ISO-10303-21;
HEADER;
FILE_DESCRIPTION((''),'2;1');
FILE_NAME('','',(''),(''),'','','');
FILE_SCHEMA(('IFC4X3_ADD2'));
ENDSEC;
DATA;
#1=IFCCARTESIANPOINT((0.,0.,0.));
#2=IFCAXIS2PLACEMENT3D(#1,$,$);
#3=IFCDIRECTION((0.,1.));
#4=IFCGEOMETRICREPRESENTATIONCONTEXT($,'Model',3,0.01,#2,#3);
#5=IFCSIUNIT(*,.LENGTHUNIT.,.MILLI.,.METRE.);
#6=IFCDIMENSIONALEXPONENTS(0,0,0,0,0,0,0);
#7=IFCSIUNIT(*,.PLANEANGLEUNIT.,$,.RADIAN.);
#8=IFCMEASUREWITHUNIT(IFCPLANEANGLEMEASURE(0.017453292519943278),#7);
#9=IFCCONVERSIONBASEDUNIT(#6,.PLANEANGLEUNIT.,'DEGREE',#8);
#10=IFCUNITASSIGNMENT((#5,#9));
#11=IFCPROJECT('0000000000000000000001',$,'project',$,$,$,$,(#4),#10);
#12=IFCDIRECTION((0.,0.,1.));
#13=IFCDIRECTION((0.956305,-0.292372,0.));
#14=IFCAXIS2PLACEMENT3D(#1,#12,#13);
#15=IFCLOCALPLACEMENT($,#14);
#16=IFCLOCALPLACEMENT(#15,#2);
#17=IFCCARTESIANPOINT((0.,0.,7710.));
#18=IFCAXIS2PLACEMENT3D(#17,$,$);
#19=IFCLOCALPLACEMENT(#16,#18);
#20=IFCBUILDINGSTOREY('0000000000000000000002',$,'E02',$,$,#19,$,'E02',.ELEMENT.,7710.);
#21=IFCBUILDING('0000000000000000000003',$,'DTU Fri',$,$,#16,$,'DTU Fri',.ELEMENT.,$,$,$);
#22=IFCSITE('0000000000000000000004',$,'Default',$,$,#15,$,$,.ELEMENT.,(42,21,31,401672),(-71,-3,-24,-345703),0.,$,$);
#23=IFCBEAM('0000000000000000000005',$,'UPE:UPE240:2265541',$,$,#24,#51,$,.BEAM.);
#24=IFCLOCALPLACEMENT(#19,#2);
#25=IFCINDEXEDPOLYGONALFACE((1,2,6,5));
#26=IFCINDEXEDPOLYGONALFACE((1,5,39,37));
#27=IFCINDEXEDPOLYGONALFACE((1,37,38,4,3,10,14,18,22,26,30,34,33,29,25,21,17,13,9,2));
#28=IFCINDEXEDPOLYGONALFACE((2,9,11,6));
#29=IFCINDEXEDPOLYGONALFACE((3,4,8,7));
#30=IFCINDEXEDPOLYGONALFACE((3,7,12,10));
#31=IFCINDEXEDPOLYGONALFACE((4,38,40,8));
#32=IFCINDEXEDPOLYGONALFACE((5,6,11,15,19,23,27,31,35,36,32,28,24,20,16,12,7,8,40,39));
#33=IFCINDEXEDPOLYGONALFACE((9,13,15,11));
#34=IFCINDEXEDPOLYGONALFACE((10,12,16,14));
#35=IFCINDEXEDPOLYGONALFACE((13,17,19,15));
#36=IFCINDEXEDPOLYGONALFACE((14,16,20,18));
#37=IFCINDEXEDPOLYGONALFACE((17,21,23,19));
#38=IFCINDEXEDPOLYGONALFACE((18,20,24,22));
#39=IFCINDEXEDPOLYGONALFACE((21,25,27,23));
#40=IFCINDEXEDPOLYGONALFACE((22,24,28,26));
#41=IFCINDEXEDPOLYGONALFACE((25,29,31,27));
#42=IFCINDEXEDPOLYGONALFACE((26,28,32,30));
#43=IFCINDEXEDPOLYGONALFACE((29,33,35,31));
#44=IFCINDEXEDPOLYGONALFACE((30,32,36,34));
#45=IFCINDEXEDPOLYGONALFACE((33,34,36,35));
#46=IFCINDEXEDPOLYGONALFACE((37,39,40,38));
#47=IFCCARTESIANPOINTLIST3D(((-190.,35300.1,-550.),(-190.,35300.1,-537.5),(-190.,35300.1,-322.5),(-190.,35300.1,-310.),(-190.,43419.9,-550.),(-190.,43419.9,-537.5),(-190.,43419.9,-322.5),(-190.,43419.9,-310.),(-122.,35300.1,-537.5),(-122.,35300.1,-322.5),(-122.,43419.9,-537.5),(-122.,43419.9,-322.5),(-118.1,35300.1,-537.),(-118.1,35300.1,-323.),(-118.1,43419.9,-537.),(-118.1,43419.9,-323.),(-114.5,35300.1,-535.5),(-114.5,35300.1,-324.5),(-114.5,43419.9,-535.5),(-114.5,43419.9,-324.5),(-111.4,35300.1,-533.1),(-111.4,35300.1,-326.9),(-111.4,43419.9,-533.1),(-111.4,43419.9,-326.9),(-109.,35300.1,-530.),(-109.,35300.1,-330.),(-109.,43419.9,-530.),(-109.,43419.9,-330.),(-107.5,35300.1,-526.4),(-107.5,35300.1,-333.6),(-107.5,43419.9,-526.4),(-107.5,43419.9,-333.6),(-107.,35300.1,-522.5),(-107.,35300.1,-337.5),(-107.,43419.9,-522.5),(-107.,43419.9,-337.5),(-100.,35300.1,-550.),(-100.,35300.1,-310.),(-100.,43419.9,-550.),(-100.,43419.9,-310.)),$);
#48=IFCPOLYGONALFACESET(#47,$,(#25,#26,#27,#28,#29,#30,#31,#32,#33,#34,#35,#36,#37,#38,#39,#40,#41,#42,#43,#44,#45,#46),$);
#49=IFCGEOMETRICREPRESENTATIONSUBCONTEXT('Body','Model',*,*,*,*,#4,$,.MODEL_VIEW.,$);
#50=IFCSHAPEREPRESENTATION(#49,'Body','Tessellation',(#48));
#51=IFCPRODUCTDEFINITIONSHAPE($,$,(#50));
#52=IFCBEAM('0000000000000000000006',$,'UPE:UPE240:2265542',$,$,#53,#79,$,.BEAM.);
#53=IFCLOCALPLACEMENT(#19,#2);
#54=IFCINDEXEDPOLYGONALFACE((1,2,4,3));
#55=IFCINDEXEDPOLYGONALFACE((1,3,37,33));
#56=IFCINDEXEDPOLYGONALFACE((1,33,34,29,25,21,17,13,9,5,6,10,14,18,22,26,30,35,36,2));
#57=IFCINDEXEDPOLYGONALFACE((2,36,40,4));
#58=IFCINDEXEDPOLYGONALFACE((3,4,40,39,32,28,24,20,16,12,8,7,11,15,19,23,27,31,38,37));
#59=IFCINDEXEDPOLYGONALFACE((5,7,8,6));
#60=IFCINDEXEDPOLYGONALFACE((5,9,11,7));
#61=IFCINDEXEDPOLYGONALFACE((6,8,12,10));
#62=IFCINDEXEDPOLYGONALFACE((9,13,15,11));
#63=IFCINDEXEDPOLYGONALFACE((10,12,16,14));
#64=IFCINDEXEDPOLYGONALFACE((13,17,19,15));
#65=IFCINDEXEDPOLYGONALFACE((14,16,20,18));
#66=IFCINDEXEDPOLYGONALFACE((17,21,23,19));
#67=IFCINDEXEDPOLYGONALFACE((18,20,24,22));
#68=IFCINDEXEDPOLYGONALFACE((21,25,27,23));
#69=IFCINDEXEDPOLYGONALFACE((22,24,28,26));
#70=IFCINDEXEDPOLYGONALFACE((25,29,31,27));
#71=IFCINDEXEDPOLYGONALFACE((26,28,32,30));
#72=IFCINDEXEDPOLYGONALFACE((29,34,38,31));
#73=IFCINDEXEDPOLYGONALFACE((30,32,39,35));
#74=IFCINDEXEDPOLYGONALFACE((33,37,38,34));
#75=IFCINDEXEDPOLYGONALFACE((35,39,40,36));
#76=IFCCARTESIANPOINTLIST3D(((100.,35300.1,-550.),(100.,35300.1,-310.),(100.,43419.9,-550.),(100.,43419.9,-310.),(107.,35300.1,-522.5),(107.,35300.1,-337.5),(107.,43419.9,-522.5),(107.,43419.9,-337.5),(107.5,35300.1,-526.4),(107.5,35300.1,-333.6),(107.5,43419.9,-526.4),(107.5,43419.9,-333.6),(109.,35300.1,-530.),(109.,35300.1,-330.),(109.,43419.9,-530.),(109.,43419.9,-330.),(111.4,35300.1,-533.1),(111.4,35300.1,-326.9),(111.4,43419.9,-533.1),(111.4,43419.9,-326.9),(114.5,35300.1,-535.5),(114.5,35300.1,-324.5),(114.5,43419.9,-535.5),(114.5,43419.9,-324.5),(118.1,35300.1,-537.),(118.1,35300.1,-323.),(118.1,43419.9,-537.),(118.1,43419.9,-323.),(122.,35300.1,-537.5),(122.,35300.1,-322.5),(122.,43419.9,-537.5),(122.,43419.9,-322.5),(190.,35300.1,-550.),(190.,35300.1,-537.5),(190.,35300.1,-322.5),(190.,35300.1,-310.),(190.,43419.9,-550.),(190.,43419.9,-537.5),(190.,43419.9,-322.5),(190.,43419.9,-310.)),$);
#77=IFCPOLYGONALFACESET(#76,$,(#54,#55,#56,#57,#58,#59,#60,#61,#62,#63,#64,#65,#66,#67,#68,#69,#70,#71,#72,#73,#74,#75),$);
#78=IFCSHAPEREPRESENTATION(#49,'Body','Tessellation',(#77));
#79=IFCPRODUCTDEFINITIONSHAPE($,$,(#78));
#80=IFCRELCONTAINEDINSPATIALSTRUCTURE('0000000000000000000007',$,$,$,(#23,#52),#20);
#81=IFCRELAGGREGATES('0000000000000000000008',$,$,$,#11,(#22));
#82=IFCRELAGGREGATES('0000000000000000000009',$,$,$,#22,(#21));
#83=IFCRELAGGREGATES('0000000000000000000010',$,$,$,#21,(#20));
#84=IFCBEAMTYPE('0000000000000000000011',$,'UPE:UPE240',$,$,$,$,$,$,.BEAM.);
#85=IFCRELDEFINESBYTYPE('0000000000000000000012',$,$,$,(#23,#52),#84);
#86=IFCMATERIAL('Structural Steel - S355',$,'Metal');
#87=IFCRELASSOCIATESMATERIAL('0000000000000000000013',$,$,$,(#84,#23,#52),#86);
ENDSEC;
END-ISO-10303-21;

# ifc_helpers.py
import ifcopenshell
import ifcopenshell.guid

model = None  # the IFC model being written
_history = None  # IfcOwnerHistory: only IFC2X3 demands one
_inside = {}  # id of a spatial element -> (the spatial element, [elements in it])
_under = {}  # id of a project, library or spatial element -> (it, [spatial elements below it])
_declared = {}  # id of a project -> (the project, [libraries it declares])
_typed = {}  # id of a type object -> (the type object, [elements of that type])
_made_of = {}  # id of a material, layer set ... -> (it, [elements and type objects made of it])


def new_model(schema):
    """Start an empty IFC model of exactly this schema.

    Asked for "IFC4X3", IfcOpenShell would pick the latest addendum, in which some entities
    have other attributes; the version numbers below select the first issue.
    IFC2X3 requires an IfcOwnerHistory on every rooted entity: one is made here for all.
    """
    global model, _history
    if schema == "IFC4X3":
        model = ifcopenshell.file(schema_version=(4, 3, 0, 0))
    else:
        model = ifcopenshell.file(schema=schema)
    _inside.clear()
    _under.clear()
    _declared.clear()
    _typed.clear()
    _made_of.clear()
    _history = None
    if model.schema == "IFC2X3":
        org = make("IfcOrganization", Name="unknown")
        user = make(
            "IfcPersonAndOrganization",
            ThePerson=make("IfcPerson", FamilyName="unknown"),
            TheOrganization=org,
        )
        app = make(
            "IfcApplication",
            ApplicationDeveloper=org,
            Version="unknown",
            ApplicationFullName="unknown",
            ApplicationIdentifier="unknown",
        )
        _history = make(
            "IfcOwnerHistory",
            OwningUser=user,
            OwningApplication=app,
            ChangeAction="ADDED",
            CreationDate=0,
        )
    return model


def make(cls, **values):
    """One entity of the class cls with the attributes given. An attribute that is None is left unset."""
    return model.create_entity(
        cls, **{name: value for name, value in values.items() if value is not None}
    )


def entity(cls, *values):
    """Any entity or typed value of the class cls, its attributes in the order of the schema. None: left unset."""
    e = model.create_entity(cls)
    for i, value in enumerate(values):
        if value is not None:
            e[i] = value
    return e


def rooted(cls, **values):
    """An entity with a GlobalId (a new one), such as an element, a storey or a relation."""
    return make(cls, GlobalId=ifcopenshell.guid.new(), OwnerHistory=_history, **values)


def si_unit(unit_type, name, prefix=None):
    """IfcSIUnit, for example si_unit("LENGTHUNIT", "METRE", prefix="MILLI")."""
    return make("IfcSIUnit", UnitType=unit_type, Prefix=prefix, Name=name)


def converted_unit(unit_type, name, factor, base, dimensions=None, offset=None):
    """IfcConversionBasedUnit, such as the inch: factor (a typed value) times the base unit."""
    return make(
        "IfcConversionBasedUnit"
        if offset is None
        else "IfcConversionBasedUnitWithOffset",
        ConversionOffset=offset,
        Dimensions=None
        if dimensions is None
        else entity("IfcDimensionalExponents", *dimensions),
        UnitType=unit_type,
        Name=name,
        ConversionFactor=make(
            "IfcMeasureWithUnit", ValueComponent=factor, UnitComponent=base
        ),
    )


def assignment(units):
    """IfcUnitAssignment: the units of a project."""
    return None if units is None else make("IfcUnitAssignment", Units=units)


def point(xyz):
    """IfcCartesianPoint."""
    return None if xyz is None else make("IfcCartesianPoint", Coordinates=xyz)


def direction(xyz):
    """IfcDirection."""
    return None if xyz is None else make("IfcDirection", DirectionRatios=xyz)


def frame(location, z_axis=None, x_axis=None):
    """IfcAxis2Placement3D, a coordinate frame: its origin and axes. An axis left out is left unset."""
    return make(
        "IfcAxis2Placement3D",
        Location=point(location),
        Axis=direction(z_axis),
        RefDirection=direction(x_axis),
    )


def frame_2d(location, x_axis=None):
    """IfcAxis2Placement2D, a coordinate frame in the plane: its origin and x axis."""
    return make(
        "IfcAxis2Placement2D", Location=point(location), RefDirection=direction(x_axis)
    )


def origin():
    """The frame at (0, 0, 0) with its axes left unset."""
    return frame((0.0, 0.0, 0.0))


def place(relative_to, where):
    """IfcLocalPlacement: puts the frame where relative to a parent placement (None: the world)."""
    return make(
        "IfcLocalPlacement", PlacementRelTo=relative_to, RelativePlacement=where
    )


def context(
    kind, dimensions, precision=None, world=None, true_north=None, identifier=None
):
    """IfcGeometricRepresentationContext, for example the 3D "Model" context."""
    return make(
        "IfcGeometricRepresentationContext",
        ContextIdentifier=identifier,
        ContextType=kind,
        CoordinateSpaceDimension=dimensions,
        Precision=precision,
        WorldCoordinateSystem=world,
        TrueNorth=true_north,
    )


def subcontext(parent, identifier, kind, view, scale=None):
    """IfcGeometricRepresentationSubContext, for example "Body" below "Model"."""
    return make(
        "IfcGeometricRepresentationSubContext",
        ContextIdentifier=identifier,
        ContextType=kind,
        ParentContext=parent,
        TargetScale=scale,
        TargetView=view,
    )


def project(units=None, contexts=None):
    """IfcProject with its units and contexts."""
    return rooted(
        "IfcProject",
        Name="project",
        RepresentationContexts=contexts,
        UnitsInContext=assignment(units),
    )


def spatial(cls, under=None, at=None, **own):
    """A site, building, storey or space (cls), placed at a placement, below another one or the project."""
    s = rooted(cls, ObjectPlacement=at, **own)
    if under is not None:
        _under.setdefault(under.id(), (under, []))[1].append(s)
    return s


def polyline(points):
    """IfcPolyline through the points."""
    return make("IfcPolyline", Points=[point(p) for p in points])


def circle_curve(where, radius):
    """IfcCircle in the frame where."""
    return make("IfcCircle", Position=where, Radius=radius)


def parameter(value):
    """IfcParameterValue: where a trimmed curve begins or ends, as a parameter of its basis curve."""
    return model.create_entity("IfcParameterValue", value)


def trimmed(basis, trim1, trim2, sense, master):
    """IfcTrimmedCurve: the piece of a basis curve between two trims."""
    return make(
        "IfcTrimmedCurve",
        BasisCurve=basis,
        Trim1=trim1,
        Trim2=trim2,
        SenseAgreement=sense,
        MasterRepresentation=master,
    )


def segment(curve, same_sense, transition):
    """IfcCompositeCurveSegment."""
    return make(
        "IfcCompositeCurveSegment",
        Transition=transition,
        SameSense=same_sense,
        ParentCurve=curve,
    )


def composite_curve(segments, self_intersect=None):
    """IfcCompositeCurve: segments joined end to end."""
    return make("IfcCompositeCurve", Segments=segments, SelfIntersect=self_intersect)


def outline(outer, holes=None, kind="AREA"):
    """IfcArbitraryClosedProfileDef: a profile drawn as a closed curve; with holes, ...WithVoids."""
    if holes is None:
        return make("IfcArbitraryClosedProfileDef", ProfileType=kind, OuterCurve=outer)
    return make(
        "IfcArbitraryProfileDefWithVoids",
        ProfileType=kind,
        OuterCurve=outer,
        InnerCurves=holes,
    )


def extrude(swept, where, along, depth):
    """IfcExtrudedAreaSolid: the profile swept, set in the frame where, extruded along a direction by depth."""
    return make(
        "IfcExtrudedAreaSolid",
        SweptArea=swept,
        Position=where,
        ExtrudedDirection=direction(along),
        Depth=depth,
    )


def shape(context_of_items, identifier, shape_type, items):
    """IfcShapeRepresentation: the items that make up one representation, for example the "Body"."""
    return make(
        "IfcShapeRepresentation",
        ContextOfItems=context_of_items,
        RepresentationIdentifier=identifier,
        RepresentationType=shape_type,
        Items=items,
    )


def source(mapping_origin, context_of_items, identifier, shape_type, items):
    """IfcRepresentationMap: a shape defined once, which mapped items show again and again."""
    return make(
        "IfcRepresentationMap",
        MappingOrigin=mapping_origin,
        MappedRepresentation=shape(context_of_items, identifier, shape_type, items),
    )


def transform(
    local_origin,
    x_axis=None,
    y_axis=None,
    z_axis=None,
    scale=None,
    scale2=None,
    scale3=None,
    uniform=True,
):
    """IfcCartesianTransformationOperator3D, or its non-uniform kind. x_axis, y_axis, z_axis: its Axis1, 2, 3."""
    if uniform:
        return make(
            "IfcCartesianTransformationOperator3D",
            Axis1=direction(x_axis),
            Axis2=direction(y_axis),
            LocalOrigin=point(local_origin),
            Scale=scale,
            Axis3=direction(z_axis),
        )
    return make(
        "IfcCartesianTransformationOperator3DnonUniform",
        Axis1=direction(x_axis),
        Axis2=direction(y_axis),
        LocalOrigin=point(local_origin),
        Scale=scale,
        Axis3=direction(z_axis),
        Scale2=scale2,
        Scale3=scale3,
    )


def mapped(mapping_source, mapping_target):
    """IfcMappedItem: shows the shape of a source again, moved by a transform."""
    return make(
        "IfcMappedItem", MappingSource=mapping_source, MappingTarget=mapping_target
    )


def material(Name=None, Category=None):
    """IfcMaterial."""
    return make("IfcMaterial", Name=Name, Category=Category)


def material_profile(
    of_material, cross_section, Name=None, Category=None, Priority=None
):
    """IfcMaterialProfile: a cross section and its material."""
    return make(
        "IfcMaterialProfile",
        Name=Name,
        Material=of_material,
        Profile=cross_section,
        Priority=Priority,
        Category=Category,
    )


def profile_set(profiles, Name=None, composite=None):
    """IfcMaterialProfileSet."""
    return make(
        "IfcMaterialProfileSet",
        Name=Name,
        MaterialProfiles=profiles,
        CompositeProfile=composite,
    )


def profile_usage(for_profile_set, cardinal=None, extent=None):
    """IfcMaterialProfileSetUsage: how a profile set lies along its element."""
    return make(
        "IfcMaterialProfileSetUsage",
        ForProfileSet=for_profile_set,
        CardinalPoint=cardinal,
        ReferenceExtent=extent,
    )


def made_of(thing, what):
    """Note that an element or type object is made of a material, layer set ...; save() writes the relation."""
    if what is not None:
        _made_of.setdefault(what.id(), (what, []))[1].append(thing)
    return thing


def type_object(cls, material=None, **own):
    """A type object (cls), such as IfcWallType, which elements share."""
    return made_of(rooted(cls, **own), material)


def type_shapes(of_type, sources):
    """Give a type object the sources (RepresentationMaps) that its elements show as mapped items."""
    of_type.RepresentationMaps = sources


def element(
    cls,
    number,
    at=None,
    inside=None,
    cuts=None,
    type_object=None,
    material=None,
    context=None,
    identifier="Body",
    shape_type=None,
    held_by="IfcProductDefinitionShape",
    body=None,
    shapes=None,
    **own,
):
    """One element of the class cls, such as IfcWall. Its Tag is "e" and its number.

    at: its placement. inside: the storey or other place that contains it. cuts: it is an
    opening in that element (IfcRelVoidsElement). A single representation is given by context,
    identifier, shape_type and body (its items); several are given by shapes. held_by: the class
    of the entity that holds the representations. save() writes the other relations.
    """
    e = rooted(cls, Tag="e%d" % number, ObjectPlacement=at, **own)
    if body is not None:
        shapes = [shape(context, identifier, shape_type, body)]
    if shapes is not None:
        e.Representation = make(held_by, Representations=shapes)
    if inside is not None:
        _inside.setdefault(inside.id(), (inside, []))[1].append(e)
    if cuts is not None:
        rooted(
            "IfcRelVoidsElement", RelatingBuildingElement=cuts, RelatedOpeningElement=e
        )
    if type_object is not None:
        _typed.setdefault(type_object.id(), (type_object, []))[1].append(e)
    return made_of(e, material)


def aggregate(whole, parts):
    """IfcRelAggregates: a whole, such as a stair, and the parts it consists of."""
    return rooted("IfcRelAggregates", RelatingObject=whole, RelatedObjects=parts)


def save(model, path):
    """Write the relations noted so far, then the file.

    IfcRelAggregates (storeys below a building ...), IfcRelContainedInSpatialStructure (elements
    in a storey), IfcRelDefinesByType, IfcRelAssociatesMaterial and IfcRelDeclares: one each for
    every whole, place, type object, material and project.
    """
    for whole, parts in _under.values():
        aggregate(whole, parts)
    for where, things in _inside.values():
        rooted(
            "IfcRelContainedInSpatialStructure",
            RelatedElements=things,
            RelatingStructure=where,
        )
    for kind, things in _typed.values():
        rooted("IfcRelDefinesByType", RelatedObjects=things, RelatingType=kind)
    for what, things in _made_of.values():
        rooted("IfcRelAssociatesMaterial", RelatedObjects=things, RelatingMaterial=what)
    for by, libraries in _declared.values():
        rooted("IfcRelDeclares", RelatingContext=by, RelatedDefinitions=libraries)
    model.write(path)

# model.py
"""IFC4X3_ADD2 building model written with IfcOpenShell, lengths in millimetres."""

from ifc_helpers import new_model, entity, si_unit, converted_unit, direction, frame, frame_2d, origin, place, context, subcontext, project, spatial, polyline, circle_curve, parameter, trimmed, segment, composite_curve, outline, extrude, source, transform, mapped, material, material_profile, profile_set, profile_usage, type_object, type_shapes, element, save


model = new_model("IFC4X3_ADD2")

# Units and contexts
model_context = context("Model", 3, precision=0.01, world=origin(), true_north=direction((0.0, 1.0)))
body_context = subcontext(model_context, "Body", "Model", "MODEL_VIEW")
ifc_project = project(units=[si_unit("LENGTHUNIT", "METRE", prefix="MILLI"), converted_unit("PLANEANGLEUNIT", "DEGREE", entity("IfcPlaneAngleMeasure", 0.017453292519943278), si_unit("PLANEANGLEUNIT", "RADIAN"), dimensions=[0, 0, 0, 0, 0, 0, 0])], contexts=[model_context])

# Site, building, storey
site_placement = place(None, frame((0.0, 0.0, 0.0), z_axis=(0.0, 0.0, 1.0), x_axis=(0.956305, -0.292372, 0.0)))
site = spatial("IfcSite", under=ifc_project, at=site_placement, Name="Default", CompositionType="ELEMENT", RefLatitude=(42, 21, 31, 401672), RefLongitude=(-71, -3, -24, -345703), RefElevation=0.0)
building_placement = place(site_placement, origin())
building = spatial("IfcBuilding", under=site, at=building_placement, Name="DTU Fri", LongName="DTU Fri", CompositionType="ELEMENT")
storey_placement = place(building_placement, frame((0.0, 0.0, 7710.0)))
storey = spatial("IfcBuildingStorey", under=building, at=storey_placement, Name="E02", LongName="E02", CompositionType="ELEMENT", Elevation=7710.0)

# Beams
ifc_material_1 = material(Name="Structural Steel - S355", Category="Metal")
ifc_material_profile_1 = material_profile(ifc_material_1, outline(composite_curve([segment(polyline([(-120.0, -48.2), (-107.5, -48.2)]), True, "CONTINUOUS"), segment(polyline([(-107.5, -48.2), (-107.5, 19.8)]), True, "CONTINUOUS"), segment(trimmed(circle_curve(frame_2d((-92.5, 19.8), x_axis=(-1.0, 0.0)), 15.0), [parameter(270.0)], [parameter(0.0)], True, "PARAMETER"), False, "CONTINUOUS"), segment(polyline([(-92.5, 34.8), (92.5, 34.8)]), True, "CONTINUOUS"), segment(trimmed(circle_curve(frame_2d((92.5, 19.8), x_axis=(0.0, 1.0)), 15.0), [parameter(270.0)], [parameter(0.0)], True, "PARAMETER"), False, "CONTINUOUS"), segment(polyline([(107.5, 19.8), (107.5, -48.2)]), True, "CONTINUOUS"), segment(polyline([(107.5, -48.2), (120.0, -48.2)]), True, "CONTINUOUS"), segment(polyline([(120.0, -48.2), (120.0, 41.8)]), True, "CONTINUOUS"), segment(polyline([(120.0, 41.8), (-120.0, 41.8)]), True, "CONTINUOUS"), segment(polyline([(-120.0, 41.8), (-120.0, -48.2)]), True, "CONTINUOUS")], self_intersect=False)), Name="UPE240")
ifc_profile_set_1 = profile_set([ifc_material_profile_1], Name="UPE240")
ifc_profile_usage_1 = profile_usage(ifc_profile_set_1, cardinal=8)
beam_type_1 = type_object("IfcBeamType", Name="UPE:UPE240", PredefinedType="BEAM", material=ifc_profile_set_1)
shared_shape_1 = source(origin(), body_context, "Body", "SweptSolid", [
    extrude(outline(composite_curve([segment(polyline([(-120.0, -48.2), (-107.5, -48.2)]), True, "CONTINUOUS"), segment(polyline([(-107.5, -48.2), (-107.5, 19.8)]), True, "CONTINUOUS"), segment(trimmed(circle_curve(frame_2d((-92.5, 19.8), x_axis=(-1.0, 0.0)), 15.0), [parameter(270.0)], [parameter(0.0)], True, "PARAMETER"), False, "CONTINUOUS"), segment(polyline([(-92.5, 34.8), (92.5, 34.8)]), True, "CONTINUOUS"), segment(trimmed(circle_curve(frame_2d((92.5, 19.8), x_axis=(0.0, 1.0)), 15.0), [parameter(270.0)], [parameter(0.0)], True, "PARAMETER"), False, "CONTINUOUS"), segment(polyline([(107.5, 19.8), (107.5, -48.2)]), True, "CONTINUOUS"), segment(polyline([(107.5, -48.2), (120.0, -48.2)]), True, "CONTINUOUS"), segment(polyline([(120.0, -48.2), (120.0, 41.8)]), True, "CONTINUOUS"), segment(polyline([(120.0, 41.8), (-120.0, 41.8)]), True, "CONTINUOUS"), segment(polyline([(-120.0, 41.8), (-120.0, -48.2)]), True, "CONTINUOUS")], self_intersect=False)), frame((-4059.9, -13.9, 0.0), z_axis=(1.0, 0.0, 0.0), x_axis=(0.0, 0.0, -1.0)), (0.0, 0.0, 1.0), 8119.8),
])
type_shapes(beam_type_1, [shared_shape_1])
for number, where, z_axis, x_axis, name in (
    (1, (-127.9, 39360.0, -430.0), (0.0, 0.0, 1.0), (0.0, -1.0, 0.0), "UPE:UPE240:2265541"),
    (2, (127.9, 39360.0, -430.0), (0.0, 0.0, 1.0), (0.0, 1.0, 0.0), "UPE:UPE240:2265542"),
):
    element("IfcBeam", number, at=place(storey_placement, frame(where, z_axis=z_axis, x_axis=x_axis)), inside=storey, type_object=beam_type_1, material=ifc_profile_usage_1, Name=name, PredefinedType="BEAM", context=body_context, shape_type="MappedRepresentation", body=[
        mapped(shared_shape_1, transform((0.0, 0.0, 0.0), scale=1.0)),
    ])

save(model, "model.ifc")
